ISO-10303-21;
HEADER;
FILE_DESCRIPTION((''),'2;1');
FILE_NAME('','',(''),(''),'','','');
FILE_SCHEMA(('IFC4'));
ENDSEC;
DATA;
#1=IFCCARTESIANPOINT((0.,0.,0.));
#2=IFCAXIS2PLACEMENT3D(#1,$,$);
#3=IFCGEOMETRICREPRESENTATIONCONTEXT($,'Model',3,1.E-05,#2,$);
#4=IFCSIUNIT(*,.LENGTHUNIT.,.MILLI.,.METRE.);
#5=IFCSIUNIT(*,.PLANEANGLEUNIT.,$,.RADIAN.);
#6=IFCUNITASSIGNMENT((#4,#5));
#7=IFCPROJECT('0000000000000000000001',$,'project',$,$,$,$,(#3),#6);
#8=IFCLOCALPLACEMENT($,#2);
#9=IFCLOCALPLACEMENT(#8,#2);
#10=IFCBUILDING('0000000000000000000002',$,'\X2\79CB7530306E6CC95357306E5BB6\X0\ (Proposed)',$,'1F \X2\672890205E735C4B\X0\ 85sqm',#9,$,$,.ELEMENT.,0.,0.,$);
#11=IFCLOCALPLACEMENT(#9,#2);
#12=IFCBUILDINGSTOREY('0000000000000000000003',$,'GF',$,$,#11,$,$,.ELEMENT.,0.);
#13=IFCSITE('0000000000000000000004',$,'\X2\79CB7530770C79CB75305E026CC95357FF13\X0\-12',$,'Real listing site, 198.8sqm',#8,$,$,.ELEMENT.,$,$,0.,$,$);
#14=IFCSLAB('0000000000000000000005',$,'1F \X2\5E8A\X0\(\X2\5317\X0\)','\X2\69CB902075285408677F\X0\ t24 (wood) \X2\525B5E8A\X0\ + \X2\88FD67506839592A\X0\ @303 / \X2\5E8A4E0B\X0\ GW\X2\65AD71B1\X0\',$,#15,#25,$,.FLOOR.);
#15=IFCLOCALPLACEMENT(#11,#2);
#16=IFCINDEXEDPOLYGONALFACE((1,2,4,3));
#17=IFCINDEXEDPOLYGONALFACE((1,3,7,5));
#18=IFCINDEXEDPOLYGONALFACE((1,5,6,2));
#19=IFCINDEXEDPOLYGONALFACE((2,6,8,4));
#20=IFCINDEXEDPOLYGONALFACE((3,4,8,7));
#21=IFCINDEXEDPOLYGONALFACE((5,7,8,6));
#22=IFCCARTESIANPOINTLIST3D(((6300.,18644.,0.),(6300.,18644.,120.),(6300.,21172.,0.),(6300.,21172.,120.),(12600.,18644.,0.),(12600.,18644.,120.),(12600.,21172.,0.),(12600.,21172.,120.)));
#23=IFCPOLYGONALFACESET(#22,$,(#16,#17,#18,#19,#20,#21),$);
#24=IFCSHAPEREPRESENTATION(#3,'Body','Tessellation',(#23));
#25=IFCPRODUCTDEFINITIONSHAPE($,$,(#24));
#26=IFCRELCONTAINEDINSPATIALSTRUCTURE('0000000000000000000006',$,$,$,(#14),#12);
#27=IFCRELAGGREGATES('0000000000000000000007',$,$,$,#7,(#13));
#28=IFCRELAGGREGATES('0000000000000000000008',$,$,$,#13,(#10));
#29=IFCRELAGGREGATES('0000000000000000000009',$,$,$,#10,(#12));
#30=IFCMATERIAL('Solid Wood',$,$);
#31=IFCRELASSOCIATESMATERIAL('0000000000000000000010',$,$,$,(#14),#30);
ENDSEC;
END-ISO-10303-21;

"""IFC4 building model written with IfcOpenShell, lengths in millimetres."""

from ifc_helpers import new_model, si_unit, frame, frame_2d, origin, place, context, project, spatial, rectangle, extrude, material, element, save


model = new_model("IFC4")

# Units and contexts
model_context = context("Model", 3, precision=1e-05, world=origin())
ifc_project = project(units=[si_unit("LENGTHUNIT", "METRE", prefix="MILLI"), si_unit("PLANEANGLEUNIT", "RADIAN")], contexts=[model_context])

# Site, building, storey
site_placement = place(None, origin())
site = spatial("IfcSite", under=ifc_project, at=site_placement, Name="秋田県秋田市泉南３-12", ObjectType="Real listing site, 198.8sqm", CompositionType="ELEMENT", RefElevation=0.0)
building_placement = place(site_placement, origin())
building = spatial("IfcBuilding", under=site, at=building_placement, Name="秋田の泉南の家 (Proposed)", ObjectType="1F 木造平屋 85sqm", CompositionType="ELEMENT", ElevationOfRefHeight=0.0, ElevationOfTerrain=0.0)
storey_placement = place(building_placement, origin())
storey = spatial("IfcBuildingStorey", under=building, at=storey_placement, Name="GF", CompositionType="ELEMENT", Elevation=0.0)

# Slab
ifc_material_1 = material(Name="Solid Wood")
slab_1_placement = place(storey_placement, frame((3150.0, 9322.0, 0.0)))
element("IfcSlab", 1, at=slab_1_placement, inside=storey, material=ifc_material_1, Name="1F 床(北)", Description="構造用合板 t24 (wood) 剛床 + 製材根太 @303 / 床下 GW断熱", PredefinedType="FLOOR", context=model_context, shape_type="SweptSolid", body=[
    extrude(rectangle(XDim=6300.0, YDim=2528.0, at=frame_2d((3150.0, 1264.0))), frame((3150.0, 9322.0, 0.0)), (0.0, 0.0, 1.0), 120.0),
])

save(model, "model.ifc")
